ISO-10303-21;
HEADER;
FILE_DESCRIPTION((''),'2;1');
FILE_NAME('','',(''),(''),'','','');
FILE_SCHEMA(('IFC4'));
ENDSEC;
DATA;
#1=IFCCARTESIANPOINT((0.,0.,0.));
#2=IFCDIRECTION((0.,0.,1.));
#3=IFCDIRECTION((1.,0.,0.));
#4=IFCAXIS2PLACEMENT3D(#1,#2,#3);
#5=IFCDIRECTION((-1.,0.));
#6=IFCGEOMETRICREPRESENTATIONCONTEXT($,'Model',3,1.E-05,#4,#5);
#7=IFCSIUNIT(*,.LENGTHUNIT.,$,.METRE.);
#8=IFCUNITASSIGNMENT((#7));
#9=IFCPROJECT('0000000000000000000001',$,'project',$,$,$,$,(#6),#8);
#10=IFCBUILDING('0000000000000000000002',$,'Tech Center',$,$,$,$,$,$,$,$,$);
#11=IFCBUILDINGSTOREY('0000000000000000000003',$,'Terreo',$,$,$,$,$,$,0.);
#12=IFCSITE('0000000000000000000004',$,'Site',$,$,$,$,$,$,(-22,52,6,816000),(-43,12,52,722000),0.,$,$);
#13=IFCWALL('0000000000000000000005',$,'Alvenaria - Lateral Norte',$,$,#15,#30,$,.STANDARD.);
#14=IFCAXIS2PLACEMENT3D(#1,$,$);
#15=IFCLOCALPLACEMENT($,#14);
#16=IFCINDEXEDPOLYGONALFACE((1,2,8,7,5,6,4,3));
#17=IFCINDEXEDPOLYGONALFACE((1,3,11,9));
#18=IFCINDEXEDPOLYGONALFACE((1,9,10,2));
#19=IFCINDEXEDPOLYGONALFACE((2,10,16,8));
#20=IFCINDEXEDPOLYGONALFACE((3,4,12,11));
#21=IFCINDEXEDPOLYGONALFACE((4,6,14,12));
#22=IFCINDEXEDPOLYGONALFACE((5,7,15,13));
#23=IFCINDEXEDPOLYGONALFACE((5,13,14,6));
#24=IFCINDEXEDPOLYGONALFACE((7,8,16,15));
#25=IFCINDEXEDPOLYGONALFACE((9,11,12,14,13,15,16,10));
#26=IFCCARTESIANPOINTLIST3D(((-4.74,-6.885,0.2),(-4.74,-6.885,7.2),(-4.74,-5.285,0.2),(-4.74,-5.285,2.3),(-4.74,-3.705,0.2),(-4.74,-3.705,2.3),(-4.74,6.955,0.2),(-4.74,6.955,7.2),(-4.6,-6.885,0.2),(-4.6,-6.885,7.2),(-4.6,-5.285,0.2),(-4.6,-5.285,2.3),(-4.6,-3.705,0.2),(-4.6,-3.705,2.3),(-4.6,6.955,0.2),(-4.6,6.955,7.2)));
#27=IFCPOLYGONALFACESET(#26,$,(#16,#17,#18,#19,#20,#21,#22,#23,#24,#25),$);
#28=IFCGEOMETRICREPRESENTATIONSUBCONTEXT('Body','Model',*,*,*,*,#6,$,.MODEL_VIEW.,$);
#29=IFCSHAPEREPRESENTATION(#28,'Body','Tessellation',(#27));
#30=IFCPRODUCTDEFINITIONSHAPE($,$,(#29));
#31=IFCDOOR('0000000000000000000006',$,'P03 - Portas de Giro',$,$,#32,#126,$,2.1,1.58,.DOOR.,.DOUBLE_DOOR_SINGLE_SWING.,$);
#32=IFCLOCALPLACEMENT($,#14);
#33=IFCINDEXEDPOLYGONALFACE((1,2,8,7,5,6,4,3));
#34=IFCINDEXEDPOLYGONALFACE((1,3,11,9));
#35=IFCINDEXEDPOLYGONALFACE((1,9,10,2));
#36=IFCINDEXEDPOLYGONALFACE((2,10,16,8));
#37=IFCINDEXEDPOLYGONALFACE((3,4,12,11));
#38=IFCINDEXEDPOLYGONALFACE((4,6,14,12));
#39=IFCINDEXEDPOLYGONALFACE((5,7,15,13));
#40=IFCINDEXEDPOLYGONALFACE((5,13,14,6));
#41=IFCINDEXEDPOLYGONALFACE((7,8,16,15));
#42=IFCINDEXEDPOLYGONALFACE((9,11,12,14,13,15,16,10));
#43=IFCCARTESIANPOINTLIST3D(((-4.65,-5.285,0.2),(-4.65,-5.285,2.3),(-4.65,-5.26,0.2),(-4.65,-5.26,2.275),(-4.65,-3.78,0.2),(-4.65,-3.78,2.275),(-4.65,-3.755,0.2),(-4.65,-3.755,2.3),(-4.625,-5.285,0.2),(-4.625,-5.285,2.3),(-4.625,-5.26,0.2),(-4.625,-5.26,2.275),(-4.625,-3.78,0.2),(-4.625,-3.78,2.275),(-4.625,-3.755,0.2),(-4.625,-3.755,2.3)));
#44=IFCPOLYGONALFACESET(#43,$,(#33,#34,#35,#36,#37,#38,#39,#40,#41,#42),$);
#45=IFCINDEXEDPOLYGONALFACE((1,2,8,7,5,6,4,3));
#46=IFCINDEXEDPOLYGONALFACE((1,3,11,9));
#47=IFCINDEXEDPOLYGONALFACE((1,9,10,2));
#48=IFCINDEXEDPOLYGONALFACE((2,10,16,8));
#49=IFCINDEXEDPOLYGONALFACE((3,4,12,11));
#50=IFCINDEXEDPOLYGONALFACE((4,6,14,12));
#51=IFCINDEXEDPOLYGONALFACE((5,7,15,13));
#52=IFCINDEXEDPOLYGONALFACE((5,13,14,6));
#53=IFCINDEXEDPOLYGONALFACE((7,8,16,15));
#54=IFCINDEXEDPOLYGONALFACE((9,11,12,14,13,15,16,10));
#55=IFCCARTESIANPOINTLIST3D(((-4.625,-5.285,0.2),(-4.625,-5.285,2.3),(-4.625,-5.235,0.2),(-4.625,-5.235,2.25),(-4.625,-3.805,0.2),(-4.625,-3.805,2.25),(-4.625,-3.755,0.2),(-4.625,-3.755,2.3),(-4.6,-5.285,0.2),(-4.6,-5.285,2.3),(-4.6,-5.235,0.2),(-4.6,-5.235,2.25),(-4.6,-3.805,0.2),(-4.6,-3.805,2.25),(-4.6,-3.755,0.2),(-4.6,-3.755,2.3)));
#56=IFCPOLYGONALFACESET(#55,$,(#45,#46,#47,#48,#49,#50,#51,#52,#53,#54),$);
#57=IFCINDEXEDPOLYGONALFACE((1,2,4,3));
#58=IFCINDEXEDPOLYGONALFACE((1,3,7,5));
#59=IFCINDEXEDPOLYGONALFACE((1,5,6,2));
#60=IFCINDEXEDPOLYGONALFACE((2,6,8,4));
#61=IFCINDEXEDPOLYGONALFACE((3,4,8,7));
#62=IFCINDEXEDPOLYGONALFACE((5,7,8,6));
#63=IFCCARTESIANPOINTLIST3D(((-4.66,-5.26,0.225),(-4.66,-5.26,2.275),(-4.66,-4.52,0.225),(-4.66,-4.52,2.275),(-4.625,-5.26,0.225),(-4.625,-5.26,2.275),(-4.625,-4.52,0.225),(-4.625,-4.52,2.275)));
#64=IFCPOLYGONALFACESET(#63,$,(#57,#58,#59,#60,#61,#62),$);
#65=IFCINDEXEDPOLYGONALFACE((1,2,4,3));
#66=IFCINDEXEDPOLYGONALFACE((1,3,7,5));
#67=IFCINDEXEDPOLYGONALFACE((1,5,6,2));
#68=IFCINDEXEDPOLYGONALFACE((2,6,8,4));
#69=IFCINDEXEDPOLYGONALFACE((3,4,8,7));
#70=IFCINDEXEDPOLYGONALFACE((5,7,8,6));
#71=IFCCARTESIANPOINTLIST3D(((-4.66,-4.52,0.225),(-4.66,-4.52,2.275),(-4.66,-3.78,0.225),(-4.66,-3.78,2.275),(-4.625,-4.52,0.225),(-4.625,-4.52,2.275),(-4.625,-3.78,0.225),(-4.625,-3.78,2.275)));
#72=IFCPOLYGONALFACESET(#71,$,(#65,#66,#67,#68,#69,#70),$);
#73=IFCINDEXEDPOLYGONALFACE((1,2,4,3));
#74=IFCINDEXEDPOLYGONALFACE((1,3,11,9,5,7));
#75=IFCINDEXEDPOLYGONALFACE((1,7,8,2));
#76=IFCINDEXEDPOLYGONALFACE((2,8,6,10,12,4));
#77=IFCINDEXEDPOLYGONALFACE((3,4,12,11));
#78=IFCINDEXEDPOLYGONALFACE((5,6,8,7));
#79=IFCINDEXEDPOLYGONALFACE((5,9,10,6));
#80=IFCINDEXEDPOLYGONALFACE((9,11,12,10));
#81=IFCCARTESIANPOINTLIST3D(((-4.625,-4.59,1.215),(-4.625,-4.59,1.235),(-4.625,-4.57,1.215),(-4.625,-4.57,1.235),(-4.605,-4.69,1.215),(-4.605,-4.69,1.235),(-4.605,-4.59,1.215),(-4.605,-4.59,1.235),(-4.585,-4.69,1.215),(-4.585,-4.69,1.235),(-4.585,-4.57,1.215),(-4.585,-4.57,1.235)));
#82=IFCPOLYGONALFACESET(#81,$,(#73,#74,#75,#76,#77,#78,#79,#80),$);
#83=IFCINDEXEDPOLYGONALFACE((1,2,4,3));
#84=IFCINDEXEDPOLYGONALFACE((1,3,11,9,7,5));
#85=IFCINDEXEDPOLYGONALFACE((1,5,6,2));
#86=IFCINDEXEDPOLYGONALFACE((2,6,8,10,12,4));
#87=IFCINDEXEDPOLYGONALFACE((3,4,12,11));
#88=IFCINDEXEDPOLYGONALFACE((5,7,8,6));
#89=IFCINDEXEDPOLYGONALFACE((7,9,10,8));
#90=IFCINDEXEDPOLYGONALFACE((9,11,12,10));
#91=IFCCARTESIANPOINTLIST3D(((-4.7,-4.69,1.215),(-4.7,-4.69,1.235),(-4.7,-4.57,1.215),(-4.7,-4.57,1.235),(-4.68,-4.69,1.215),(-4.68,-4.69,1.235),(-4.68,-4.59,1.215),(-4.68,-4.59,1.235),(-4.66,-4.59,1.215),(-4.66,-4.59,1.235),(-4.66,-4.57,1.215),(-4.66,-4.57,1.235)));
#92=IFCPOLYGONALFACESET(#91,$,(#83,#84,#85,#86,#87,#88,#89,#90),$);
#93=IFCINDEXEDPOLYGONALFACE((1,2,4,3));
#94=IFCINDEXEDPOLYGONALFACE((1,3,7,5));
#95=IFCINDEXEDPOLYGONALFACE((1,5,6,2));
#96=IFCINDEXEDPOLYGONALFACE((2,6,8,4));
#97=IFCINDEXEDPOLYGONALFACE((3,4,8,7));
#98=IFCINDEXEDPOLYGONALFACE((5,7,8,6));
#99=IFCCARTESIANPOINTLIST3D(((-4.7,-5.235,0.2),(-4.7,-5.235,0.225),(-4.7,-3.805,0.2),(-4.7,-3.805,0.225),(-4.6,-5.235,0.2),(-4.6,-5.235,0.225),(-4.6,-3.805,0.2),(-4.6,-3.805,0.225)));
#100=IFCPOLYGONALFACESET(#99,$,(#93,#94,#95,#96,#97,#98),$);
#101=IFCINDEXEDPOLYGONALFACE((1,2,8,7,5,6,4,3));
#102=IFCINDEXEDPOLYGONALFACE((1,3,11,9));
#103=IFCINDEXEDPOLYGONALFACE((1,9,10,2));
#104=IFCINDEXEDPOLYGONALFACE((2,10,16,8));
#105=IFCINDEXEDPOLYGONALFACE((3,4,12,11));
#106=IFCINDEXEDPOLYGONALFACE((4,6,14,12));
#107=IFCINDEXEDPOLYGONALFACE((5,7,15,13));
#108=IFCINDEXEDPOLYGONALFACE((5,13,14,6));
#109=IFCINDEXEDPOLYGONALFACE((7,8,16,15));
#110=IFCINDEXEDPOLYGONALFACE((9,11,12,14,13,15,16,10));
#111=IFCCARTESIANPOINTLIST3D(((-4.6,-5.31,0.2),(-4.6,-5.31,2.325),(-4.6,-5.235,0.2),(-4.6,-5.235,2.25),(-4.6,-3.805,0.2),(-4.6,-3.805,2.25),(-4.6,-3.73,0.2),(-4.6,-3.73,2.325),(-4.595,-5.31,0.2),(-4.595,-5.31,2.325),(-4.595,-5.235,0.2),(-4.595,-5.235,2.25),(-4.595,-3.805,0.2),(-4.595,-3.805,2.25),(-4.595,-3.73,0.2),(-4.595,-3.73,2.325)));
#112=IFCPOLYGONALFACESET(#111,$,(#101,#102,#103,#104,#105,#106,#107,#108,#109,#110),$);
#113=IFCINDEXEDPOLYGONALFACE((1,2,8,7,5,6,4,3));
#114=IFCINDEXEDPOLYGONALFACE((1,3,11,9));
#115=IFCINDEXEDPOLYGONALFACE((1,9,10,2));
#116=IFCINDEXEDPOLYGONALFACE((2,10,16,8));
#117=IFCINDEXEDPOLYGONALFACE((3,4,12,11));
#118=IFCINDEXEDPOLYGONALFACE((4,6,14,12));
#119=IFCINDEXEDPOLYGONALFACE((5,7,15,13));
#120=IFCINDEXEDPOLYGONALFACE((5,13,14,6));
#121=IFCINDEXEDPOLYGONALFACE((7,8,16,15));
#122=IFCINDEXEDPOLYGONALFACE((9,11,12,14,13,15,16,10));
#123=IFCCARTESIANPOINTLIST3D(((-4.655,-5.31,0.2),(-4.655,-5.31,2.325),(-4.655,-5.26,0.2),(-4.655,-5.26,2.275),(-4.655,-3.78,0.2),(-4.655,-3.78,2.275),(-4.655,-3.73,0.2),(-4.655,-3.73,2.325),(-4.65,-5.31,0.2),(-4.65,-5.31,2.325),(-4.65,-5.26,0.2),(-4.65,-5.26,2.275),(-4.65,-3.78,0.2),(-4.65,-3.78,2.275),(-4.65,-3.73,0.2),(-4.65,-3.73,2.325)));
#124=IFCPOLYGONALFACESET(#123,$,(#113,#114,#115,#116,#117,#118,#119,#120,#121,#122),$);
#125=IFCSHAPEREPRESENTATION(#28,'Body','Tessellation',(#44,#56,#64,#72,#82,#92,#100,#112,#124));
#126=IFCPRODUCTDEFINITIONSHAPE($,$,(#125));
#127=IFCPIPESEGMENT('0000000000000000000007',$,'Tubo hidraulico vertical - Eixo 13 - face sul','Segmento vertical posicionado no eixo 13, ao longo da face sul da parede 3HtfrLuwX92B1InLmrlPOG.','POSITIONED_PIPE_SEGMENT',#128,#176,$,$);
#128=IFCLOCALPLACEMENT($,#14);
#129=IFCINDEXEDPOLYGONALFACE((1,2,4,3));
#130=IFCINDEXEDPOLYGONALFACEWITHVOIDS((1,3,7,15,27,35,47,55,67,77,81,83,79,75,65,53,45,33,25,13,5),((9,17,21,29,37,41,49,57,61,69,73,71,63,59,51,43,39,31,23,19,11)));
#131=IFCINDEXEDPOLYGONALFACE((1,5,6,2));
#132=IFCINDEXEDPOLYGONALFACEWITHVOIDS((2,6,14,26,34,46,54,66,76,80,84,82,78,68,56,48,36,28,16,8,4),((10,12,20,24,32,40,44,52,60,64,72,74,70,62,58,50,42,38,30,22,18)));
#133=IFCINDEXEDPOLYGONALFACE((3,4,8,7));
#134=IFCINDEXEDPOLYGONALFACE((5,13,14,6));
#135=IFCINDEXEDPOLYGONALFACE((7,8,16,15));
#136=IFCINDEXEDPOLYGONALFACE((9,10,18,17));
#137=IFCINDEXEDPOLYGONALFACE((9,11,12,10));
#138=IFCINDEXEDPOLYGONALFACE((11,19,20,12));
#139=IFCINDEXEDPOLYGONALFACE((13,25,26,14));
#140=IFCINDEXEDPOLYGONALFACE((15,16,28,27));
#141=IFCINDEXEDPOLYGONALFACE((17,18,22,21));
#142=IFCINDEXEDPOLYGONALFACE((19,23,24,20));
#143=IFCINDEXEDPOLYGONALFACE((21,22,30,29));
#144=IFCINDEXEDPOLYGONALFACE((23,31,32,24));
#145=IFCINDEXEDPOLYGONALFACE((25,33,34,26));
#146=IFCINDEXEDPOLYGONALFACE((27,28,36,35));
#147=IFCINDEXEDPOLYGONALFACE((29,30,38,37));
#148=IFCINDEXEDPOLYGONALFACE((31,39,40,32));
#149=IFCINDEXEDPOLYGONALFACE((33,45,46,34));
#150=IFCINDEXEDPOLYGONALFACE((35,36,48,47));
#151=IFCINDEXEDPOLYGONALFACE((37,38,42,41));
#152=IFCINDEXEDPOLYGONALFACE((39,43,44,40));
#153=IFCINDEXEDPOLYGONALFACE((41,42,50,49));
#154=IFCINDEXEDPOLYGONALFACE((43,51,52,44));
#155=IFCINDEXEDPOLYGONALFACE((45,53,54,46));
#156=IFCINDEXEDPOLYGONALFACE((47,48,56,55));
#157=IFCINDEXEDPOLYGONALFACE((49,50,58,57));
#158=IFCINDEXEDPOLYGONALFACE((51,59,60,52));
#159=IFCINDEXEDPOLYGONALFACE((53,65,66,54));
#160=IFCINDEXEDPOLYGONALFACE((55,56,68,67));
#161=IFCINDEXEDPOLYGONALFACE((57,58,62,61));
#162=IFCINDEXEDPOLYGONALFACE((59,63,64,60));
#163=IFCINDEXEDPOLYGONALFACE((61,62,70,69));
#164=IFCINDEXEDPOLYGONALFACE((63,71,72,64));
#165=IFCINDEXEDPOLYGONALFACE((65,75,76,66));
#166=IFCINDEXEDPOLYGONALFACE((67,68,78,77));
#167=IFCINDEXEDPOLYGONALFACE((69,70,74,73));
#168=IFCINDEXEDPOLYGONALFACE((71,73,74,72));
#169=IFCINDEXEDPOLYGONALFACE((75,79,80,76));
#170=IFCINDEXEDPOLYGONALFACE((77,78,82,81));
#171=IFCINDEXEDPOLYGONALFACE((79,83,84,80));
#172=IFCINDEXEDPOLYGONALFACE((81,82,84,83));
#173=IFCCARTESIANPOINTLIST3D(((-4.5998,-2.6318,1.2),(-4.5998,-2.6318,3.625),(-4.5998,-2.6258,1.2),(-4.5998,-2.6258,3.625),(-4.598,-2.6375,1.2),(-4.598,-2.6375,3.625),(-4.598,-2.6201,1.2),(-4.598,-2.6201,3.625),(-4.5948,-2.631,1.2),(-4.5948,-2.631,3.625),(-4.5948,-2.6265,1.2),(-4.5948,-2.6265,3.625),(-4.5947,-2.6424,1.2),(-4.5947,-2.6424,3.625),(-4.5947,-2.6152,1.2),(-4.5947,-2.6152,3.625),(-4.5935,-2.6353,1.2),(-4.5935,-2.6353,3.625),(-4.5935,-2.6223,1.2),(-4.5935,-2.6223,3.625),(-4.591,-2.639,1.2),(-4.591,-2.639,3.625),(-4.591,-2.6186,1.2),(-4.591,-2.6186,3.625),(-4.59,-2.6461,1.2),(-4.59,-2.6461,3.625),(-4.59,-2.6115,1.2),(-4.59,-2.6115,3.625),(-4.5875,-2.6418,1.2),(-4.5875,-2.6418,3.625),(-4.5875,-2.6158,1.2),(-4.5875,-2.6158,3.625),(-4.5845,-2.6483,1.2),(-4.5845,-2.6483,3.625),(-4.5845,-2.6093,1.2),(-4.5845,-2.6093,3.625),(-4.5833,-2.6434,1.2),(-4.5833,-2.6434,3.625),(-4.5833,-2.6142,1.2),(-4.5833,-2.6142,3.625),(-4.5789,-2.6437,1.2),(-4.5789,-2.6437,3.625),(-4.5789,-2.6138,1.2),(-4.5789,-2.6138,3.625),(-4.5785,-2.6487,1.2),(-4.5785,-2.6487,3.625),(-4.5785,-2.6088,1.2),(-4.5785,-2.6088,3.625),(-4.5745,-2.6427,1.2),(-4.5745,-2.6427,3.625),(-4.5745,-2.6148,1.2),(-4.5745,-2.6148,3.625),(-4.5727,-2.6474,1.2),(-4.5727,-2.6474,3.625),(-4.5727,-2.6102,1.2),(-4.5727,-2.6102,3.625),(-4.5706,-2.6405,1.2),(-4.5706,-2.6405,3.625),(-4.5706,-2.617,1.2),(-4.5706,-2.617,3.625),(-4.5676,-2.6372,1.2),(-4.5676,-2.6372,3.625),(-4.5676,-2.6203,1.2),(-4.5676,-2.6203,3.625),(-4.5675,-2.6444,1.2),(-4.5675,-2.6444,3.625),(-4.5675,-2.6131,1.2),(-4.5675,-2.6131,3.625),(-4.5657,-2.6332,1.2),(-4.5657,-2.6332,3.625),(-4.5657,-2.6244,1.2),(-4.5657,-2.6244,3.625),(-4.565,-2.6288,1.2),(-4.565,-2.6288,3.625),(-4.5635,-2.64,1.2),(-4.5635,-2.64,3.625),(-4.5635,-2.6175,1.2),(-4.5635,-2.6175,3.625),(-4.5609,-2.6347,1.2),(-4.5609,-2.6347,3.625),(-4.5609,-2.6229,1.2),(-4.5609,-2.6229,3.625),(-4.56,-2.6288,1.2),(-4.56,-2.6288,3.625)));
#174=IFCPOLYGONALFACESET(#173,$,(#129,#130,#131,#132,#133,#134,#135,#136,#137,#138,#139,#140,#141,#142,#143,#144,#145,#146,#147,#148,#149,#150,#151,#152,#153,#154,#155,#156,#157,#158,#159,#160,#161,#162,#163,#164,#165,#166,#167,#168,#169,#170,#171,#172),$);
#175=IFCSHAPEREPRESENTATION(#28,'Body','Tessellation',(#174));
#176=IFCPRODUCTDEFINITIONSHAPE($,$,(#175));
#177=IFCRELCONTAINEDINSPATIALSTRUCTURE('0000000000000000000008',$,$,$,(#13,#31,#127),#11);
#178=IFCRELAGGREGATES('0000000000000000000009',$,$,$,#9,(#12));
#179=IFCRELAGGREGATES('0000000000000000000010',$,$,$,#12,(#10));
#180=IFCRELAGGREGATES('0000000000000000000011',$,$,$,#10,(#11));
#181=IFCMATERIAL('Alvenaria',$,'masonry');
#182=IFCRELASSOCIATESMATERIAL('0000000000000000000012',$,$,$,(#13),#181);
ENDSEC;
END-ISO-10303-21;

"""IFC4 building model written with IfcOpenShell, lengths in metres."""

from ifc_helpers import new_model, si_unit, direction, frame, origin_with_axes, place, context, subcontext, project, spatial, line, indexed_curve, hollow_circle, outline, extrude, material, element, fill, save


model = new_model("IFC4")

# Units and contexts
model_context = context("Model", 3, precision=1e-05, world=origin_with_axes(), true_north=direction((-1.0, 0.0)))
body_context = subcontext(model_context, "Body", "Model", "MODEL_VIEW")
ifc_project = project(units=[si_unit("LENGTHUNIT", "METRE")], contexts=[model_context])

# Site, building, storey
site = spatial("IfcSite", under=ifc_project, Name="Site", RefLatitude=(-22, 52, 6, 816000), RefLongitude=(-43, 12, 52, 722000), RefElevation=0.0)
building = spatial("IfcBuilding", under=site, Name="Tech Center")
storey = spatial("IfcBuildingStorey", under=building, Name="Terreo", Elevation=0.0)

# Wall, opening, door
ifc_material_1 = material(Name="Alvenaria", Category="masonry")
wall_1_placement = place(None, frame((-4.6, -6.885, 0.2), z_axis=(0.0, 0.0, 1.0), x_axis=(0.0, 1.0, 0.0)))
wall_1 = element("IfcWall", 1, at=wall_1_placement, inside=storey, material=ifc_material_1, Name="Alvenaria - Lateral Norte", PredefinedType="STANDARD", context=body_context, shape_type="SweptSolid", body=[
    extrude(outline(indexed_curve([(0.0, 0.0), (0.0, 0.14), (13.84, 0.14), (13.84, 0.0), (0.0, 0.0)], self_intersect=False)), origin_with_axes(), (0.0, 0.0, 1.0), 7.0),
])
opening_1_placement = place(wall_1_placement, frame((1.6, 0.0, 0.0), z_axis=(0.0, 0.0, 1.0), x_axis=(1.0, 0.0, 0.0)))
opening_1 = element("IfcOpeningElement", 2, at=opening_1_placement, cuts=wall_1, context=body_context, shape_type="SweptSolid", body=[
    extrude(outline(indexed_curve([(0.0, 0.0), (0.0, 0.34), (1.58, 0.34), (1.58, 0.0), (0.0, 0.0)], self_intersect=False)), origin_with_axes(), (0.0, 0.0, 1.0), 2.1),
])
door_1_placement = place(None, frame((-4.6, -5.285, 0.2), z_axis=(0.0, 0.0, 1.0), x_axis=(0.0, 1.0, 0.0)))
door_1 = element("IfcDoor", 3, at=door_1_placement, inside=storey, Name="P03 - Portas de Giro", OperationType="DOUBLE_DOOR_SINGLE_SWING", OverallHeight=2.1, OverallWidth=1.58, PredefinedType="DOOR", context=body_context, shape_type="SweptSolid", body=[
    extrude(outline(indexed_curve([(0.0, 0.0), (0.0, 2.1), (1.53, 2.1), (1.53, 0.0), (1.505, 0.0), (1.505, 2.075), (0.025, 2.075), (0.025, 0.0)], segments=[line(1, 2, 3, 4, 5, 6, 7, 8, 1)])), frame((0.0, 0.025, 0.0), z_axis=(0.0, -1.0, 0.0), x_axis=(1.0, 0.0, 0.0)), (0.0, 0.0, -1.0), 0.025),
    extrude(outline(indexed_curve([(0.0, 0.0), (0.0, 2.1), (1.53, 2.1), (1.53, 0.0), (1.48, 0.0), (1.48, 2.05), (0.05, 2.05), (0.05, 0.0)], segments=[line(1, 2, 3, 4, 5, 6, 7, 8, 1)])), frame((0.0, 0.0, 0.0), z_axis=(0.0, -1.0, 0.0), x_axis=(1.0, 0.0, 0.0)), (0.0, 0.0, -1.0), 0.025),
    extrude(outline(indexed_curve([(0.0, 0.0), (0.74, 0.0), (0.74, 0.035), (0.0, 0.035)], segments=[line(1, 2, 3, 4, 1)])), frame((0.025, 0.025, 0.025), z_axis=(0.0, 0.0, 1.0), x_axis=(1.0, 0.0, 0.0)), (0.0, 0.0, 1.0), 2.05),
    extrude(outline(indexed_curve([(0.0, 0.0), (0.74, 0.0), (0.74, 0.035), (0.0, 0.035)], segments=[line(1, 2, 3, 4, 1)])), frame((0.765, 0.025, 0.025), z_axis=(0.0, 0.0, 1.0), x_axis=(1.0, 0.0, 0.0)), (0.0, 0.0, 1.0), 2.05),
    extrude(outline(indexed_curve([(0.0, 0.0), (0.0, -0.04), (-0.12, -0.04), (-0.12, -0.02), (-0.02, -0.02), (-0.02, 0.0)], segments=[line(1, 2, 3, 4, 5, 6, 1)])), frame((0.715, 0.025, 1.015), z_axis=(0.0, 0.0, 1.0), x_axis=(1.0, 0.0, 0.0)), (0.0, 0.0, 1.0), 0.02),
    extrude(outline(indexed_curve([(0.0, 0.0), (0.0, 0.04), (-0.12, 0.04), (-0.12, 0.02), (-0.02, 0.02), (-0.02, 0.0)], segments=[line(1, 2, 3, 4, 5, 6, 1)])), frame((0.715, 0.06, 1.015), z_axis=(0.0, 0.0, 1.0), x_axis=(1.0, 0.0, 0.0)), (0.0, 0.0, 1.0), 0.02),
    extrude(outline(indexed_curve([(0.0, 0.0), (1.43, 0.0), (1.43, 0.1), (0.0, 0.1)], segments=[line(1, 2, 3, 4, 1)])), frame((0.05, 0.0, 0.0), z_axis=(0.0, 0.0, 1.0), x_axis=(1.0, 0.0, 0.0)), (0.0, 0.0, 1.0), 0.025),
    extrude(outline(indexed_curve([(0.0, 0.0), (0.0, 2.125), (1.58, 2.125), (1.58, 0.0), (1.505, 0.0), (1.505, 2.05), (0.075, 2.05), (0.075, 0.0)], segments=[line(1, 2, 3, 4, 5, 6, 7, 8, 1)])), frame((-0.025, -0.005, 0.0), z_axis=(0.0, -1.0, 0.0), x_axis=(1.0, 0.0, 0.0)), (0.0, 0.0, -1.0), 0.005),
    extrude(outline(indexed_curve([(0.0, 0.0), (0.0, 2.125), (1.58, 2.125), (1.58, 0.0), (1.53, 0.0), (1.53, 2.075), (0.05, 2.075), (0.05, 0.0)], segments=[line(1, 2, 3, 4, 5, 6, 7, 8, 1)])), frame((-0.025, 0.05, 0.0), z_axis=(0.0, -1.0, 0.0), x_axis=(1.0, 0.0, 0.0)), (0.0, 0.0, -1.0), 0.005),
])
fill(opening_1, door_1)

# Pipe segment
for number, where, name in (
    (4, (-4.58, -2.6288, 1.2), "Tubo hidraulico vertical - Eixo 13 - face sul"),
):
    element("IfcPipeSegment", number, at=place(None, frame(where)), inside=storey, Name=name, Description="Segmento vertical posicionado no eixo 13, ao longo da face sul da parede 3HtfrLuwX92B1InLmrlPOG.", ObjectType="POSITIONED_PIPE_SEGMENT", context=body_context, shape_type="SweptSolid", body=[
        extrude(hollow_circle(Radius=0.02, WallThickness=0.005), origin_with_axes(), (0.0, 0.0, 1.0), 2.425),
    ])

save(model, "model.ifc")
